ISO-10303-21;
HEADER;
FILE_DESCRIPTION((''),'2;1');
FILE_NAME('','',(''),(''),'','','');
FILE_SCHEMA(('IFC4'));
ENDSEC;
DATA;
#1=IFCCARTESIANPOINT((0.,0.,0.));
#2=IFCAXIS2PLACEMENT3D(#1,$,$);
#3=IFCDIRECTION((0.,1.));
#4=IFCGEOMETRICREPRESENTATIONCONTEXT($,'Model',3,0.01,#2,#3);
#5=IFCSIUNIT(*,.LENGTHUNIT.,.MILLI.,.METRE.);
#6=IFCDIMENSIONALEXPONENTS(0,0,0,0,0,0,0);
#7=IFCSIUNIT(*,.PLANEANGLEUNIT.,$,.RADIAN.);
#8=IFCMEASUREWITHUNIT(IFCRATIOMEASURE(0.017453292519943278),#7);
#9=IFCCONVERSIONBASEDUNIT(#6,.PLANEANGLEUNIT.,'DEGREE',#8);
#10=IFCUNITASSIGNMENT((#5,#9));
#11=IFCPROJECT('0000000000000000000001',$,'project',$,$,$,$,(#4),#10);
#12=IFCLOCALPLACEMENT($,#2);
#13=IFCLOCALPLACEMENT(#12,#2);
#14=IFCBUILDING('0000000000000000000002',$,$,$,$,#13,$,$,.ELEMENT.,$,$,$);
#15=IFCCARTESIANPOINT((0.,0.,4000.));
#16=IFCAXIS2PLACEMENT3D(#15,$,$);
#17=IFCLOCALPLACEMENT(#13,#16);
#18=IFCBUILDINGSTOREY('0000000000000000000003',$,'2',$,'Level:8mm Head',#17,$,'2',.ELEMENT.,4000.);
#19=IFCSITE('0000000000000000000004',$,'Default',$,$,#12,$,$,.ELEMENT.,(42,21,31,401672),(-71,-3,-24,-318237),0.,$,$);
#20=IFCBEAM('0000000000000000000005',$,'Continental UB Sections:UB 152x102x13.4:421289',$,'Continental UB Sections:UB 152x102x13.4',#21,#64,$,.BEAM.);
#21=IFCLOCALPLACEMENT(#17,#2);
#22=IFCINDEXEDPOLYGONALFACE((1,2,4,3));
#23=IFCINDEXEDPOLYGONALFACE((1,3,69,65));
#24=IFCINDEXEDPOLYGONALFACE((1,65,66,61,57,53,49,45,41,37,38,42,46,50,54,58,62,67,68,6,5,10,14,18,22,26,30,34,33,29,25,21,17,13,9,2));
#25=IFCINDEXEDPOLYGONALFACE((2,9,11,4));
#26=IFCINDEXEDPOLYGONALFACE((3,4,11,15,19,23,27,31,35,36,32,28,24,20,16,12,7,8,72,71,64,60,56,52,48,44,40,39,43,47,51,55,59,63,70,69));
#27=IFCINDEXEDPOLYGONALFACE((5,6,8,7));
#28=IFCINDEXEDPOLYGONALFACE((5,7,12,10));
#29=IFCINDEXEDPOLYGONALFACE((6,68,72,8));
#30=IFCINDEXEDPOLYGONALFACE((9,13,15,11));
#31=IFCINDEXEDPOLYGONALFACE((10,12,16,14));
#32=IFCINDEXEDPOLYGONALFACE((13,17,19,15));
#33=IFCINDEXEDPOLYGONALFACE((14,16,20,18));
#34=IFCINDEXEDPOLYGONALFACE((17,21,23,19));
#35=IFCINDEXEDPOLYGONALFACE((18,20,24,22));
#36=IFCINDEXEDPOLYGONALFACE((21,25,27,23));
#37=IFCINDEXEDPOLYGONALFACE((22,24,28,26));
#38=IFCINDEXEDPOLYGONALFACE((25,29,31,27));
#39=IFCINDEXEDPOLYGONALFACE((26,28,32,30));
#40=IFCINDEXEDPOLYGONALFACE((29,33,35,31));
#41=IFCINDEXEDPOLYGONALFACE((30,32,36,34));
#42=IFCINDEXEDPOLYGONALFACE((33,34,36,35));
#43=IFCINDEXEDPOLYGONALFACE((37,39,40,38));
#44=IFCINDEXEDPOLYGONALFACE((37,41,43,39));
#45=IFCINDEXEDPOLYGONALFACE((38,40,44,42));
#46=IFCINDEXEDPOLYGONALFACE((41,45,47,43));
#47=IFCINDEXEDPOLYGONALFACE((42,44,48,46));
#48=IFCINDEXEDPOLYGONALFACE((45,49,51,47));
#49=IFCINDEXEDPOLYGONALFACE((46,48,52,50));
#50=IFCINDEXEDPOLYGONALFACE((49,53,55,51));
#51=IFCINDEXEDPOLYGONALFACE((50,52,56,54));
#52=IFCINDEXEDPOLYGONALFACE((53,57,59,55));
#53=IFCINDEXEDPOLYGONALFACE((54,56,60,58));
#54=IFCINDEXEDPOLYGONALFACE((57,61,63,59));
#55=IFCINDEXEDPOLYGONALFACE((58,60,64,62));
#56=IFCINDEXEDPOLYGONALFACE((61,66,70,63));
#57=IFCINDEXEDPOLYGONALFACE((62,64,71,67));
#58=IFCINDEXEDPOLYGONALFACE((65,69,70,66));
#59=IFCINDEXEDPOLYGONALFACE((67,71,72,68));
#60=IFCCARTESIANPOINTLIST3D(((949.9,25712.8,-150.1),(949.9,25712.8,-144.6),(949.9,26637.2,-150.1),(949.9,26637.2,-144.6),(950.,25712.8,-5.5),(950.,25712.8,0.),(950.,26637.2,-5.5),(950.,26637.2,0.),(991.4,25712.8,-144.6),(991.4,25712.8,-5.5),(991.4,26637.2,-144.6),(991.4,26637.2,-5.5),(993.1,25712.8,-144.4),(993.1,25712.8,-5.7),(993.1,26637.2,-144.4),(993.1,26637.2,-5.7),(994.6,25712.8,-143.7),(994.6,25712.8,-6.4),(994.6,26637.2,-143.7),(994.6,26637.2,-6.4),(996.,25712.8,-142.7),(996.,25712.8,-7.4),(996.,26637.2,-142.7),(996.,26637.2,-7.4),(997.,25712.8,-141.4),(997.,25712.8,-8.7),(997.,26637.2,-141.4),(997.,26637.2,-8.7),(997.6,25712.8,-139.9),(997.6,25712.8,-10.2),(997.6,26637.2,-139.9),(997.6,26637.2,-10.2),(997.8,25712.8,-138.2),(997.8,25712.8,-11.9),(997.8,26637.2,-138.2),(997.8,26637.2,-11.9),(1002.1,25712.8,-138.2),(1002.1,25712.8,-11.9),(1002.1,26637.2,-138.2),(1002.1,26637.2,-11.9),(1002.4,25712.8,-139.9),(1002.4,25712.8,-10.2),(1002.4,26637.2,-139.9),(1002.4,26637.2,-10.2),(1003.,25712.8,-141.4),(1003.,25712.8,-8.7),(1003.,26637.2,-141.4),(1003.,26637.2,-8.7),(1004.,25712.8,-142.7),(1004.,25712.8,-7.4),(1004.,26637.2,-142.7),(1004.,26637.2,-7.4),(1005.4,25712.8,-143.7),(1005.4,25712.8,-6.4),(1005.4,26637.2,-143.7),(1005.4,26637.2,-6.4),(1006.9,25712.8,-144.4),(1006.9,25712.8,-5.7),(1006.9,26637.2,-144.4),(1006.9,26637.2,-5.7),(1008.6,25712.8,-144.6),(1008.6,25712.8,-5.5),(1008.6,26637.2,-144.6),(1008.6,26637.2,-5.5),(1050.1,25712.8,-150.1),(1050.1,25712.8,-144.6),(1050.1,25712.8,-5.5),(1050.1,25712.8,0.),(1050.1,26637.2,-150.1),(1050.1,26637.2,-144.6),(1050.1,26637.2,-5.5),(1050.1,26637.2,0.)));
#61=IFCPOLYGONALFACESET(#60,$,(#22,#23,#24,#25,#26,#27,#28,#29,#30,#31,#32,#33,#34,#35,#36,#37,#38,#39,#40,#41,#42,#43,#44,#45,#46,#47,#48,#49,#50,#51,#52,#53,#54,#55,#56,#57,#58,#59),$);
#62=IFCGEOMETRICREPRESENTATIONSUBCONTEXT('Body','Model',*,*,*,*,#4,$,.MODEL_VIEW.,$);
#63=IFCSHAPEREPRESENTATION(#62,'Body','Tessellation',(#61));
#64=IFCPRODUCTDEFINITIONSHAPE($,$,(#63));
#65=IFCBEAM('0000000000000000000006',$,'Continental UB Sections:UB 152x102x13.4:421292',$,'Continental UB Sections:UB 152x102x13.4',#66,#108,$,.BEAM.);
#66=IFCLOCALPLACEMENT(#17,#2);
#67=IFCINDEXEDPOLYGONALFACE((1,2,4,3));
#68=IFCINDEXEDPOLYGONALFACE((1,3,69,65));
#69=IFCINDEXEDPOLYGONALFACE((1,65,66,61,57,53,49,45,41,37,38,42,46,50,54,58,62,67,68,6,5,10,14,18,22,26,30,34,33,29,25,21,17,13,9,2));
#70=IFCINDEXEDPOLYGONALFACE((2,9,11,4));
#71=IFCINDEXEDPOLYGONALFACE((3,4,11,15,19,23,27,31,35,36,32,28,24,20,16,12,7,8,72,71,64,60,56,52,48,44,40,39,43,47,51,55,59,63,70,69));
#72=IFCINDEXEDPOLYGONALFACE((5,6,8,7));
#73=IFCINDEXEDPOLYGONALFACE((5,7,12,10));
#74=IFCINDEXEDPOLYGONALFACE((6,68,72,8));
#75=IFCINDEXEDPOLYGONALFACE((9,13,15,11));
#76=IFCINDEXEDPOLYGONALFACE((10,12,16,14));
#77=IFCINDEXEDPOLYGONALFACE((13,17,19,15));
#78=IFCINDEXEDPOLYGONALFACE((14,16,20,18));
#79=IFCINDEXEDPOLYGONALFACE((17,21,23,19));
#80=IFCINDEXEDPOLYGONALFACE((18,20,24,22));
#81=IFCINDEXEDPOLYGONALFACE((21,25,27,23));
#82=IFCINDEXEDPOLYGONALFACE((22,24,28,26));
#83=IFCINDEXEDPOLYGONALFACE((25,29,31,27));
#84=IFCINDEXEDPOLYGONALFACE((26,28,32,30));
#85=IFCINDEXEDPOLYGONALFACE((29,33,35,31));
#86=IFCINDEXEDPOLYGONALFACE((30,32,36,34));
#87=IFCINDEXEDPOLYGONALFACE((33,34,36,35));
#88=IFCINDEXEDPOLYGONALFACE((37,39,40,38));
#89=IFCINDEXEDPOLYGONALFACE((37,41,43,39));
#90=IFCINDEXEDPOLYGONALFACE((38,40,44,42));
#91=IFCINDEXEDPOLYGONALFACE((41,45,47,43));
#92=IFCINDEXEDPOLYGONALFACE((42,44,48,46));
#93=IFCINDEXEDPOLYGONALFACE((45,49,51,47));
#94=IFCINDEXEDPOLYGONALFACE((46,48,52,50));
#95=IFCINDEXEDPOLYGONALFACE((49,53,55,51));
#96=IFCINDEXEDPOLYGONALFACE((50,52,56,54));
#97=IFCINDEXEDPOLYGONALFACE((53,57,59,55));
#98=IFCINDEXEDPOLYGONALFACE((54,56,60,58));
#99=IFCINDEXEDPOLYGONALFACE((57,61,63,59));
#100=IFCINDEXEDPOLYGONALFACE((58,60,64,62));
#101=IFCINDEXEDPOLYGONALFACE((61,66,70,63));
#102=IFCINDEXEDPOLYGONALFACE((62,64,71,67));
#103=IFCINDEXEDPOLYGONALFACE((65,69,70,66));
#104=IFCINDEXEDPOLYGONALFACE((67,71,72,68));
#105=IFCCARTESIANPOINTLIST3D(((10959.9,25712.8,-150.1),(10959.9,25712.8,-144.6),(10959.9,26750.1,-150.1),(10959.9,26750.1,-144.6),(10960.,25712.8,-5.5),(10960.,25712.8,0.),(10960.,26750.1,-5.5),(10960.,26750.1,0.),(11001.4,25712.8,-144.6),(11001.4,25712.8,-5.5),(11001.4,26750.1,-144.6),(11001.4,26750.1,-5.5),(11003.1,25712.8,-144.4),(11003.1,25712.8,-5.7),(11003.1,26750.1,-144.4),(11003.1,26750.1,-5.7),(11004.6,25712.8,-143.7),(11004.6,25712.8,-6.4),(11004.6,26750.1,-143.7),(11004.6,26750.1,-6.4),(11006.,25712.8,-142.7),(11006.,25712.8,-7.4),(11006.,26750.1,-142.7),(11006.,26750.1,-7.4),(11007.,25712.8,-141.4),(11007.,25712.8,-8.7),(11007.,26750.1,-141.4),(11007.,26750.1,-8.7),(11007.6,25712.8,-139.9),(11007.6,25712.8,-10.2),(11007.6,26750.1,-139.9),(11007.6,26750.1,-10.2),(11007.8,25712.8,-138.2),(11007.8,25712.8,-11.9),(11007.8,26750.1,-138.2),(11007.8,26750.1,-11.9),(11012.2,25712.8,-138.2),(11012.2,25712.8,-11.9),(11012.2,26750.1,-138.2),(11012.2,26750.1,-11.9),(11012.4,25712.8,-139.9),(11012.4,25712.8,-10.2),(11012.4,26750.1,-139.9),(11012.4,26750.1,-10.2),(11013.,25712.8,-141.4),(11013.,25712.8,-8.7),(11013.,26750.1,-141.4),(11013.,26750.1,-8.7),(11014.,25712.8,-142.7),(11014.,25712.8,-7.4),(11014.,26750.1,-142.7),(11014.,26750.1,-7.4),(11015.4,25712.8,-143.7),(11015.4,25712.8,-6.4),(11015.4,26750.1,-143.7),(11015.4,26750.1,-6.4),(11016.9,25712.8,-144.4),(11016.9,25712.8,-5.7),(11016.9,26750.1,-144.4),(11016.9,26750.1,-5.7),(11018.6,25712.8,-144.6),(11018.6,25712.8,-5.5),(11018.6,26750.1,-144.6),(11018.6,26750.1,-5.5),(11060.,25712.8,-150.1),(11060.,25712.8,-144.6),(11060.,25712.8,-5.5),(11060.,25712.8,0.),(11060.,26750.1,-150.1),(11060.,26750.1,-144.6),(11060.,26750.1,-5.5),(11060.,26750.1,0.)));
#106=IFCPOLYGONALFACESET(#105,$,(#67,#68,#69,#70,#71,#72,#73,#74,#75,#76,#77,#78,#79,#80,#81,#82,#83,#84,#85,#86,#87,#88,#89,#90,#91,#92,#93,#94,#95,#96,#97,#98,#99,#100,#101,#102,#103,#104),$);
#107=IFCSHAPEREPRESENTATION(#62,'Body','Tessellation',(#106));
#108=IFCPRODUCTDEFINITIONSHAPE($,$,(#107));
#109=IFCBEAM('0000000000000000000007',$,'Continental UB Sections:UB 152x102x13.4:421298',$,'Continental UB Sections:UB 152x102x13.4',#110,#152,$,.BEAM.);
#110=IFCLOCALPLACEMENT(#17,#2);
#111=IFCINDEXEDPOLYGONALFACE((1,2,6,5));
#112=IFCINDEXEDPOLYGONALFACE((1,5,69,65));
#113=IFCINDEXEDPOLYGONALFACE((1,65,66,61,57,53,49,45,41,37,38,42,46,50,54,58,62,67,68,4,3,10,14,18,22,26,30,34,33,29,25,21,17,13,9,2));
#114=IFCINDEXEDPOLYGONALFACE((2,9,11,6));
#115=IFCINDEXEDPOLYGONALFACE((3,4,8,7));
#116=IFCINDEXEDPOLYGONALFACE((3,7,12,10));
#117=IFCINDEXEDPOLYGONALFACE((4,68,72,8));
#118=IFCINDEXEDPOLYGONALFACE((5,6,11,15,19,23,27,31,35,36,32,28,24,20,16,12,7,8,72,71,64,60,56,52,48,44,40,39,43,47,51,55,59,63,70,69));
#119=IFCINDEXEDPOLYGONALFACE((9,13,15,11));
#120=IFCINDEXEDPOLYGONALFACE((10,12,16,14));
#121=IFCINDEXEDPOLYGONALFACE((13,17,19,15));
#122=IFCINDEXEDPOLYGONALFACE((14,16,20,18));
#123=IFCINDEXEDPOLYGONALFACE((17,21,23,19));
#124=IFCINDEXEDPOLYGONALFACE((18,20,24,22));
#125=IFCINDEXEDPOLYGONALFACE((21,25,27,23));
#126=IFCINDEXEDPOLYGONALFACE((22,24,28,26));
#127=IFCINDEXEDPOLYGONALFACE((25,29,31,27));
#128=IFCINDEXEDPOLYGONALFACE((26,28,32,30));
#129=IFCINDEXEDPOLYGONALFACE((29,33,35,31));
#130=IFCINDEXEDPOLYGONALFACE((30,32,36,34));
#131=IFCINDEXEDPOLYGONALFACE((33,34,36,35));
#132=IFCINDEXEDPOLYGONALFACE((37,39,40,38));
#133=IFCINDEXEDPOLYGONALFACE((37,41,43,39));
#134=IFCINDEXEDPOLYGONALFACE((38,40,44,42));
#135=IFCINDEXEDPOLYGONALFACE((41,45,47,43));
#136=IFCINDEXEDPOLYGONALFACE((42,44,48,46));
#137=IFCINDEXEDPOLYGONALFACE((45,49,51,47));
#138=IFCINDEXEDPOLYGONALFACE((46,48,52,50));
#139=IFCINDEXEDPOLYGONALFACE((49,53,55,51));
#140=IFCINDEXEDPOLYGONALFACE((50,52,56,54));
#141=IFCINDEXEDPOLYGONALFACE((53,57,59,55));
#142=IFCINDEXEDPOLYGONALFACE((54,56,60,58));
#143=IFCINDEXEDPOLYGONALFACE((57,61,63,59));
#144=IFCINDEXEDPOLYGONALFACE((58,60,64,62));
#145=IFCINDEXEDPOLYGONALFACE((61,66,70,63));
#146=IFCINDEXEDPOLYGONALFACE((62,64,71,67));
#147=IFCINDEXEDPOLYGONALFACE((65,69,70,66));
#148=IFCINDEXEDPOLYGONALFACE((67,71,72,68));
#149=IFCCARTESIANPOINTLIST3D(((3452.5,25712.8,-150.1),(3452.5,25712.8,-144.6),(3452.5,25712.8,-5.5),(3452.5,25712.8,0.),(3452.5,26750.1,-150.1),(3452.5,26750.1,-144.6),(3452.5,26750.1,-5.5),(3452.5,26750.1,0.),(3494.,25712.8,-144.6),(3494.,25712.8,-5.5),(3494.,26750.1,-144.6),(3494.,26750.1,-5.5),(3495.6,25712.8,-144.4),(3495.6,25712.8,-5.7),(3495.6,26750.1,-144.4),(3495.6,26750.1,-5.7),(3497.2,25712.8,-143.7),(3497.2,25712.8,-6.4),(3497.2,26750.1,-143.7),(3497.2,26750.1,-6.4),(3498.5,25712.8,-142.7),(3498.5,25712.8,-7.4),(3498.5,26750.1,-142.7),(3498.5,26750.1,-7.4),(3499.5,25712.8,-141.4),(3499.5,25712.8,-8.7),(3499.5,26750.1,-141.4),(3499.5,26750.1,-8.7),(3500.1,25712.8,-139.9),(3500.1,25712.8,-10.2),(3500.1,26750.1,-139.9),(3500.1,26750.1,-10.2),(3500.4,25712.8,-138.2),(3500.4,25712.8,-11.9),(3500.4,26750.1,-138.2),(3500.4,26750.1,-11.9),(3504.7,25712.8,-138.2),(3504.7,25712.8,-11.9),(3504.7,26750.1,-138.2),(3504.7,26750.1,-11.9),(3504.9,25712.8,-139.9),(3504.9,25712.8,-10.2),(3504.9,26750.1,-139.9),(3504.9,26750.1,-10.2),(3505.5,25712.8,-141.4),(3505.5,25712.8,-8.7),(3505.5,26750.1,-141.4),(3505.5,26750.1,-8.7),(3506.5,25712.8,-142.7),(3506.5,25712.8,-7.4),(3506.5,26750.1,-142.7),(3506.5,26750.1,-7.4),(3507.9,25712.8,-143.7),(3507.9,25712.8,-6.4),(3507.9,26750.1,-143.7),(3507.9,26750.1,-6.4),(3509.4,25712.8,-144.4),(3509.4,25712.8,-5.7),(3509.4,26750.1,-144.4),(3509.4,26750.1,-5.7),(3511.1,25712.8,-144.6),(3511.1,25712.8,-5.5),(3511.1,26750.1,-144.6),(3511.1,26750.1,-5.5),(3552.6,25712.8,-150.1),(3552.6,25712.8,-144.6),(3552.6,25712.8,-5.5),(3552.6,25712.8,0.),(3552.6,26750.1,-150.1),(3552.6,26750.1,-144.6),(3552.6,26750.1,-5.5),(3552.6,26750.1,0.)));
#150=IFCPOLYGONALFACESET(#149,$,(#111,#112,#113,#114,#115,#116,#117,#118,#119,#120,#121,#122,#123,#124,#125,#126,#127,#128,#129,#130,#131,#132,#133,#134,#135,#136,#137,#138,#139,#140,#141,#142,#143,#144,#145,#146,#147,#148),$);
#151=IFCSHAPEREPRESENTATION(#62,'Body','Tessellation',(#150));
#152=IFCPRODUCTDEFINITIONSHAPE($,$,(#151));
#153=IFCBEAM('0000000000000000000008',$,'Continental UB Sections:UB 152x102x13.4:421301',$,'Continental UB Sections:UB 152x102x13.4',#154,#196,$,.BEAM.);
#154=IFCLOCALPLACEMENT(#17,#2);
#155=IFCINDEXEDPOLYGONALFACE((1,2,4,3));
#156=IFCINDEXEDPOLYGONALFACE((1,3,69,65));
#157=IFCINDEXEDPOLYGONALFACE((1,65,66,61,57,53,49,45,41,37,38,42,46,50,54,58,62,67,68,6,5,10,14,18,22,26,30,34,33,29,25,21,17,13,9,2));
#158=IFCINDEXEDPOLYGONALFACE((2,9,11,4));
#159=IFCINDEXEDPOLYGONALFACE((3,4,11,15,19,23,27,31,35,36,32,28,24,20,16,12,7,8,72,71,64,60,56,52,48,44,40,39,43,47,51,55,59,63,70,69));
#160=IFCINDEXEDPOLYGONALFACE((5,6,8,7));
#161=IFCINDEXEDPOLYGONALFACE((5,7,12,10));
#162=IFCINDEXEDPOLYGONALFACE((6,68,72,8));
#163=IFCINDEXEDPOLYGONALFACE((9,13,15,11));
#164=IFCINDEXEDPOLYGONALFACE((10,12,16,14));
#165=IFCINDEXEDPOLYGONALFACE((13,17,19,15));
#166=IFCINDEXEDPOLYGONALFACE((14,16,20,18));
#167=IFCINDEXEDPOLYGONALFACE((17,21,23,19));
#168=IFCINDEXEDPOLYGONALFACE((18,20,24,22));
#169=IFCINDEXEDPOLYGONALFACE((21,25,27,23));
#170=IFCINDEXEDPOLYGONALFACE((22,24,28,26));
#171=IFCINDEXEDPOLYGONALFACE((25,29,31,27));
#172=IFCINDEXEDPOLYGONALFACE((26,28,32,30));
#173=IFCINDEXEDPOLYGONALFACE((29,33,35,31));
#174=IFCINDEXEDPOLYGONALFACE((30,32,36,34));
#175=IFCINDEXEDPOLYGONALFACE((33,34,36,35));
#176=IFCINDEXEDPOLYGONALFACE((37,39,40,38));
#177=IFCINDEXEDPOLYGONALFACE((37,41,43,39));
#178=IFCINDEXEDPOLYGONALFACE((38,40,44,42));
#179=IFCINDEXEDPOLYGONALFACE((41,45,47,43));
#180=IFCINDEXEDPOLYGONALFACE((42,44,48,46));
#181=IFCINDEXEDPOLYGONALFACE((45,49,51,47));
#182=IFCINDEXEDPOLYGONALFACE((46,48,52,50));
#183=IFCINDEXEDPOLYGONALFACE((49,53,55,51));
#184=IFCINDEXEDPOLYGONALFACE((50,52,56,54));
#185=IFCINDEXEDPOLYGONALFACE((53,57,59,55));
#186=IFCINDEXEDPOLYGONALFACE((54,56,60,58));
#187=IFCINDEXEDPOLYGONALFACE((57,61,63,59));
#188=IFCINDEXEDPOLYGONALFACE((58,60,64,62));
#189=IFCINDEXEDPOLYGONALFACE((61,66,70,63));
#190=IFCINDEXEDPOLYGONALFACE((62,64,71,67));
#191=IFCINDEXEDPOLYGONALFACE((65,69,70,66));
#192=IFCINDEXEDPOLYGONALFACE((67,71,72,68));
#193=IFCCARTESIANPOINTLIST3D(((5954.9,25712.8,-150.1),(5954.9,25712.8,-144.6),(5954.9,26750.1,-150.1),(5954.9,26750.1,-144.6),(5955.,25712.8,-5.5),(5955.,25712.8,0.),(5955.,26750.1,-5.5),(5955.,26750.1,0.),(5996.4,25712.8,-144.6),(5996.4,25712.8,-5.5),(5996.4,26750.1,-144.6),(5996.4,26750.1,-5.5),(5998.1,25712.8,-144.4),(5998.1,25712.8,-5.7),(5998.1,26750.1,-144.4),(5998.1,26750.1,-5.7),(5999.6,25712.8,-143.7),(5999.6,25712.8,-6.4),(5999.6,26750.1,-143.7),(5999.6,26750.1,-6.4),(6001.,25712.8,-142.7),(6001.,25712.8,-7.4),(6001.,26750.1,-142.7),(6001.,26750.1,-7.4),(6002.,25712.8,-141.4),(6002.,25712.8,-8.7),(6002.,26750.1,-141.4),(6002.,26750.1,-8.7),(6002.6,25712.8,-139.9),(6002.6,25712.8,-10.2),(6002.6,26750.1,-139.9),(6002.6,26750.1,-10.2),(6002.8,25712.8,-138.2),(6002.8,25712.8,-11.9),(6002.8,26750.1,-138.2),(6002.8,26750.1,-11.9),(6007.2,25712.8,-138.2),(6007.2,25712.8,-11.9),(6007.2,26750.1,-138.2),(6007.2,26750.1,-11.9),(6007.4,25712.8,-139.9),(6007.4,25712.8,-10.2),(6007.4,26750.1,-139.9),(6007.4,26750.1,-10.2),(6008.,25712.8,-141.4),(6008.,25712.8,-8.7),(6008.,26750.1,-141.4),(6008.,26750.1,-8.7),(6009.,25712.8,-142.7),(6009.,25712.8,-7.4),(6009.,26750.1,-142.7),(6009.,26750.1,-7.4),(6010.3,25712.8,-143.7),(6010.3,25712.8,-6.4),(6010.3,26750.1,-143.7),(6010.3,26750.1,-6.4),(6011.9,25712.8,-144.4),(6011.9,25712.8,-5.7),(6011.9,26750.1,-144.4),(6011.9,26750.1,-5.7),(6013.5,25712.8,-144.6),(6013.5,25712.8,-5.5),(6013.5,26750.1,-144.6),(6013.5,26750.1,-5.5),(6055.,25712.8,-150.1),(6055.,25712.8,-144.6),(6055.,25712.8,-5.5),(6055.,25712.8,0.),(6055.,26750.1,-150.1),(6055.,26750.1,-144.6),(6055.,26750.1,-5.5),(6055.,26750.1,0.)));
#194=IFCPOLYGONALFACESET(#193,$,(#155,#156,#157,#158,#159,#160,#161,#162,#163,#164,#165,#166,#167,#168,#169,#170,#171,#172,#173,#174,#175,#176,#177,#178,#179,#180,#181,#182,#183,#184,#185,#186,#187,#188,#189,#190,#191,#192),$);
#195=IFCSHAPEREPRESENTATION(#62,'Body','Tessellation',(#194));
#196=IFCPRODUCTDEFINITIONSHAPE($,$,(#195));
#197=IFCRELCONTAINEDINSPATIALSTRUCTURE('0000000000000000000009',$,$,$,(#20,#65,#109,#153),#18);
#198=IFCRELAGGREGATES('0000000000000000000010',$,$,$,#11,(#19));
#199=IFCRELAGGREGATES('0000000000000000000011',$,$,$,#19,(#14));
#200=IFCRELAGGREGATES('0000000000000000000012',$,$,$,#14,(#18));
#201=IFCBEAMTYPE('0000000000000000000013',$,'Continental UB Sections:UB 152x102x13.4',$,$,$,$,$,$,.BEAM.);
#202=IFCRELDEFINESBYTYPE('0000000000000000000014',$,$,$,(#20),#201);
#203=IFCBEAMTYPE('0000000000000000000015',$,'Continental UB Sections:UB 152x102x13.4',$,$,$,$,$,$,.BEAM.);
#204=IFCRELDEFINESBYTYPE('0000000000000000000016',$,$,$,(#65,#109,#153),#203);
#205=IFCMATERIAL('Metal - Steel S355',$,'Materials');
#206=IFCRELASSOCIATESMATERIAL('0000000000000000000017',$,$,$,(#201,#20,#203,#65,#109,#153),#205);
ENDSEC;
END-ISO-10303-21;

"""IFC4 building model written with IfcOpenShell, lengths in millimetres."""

from ifc_helpers import new_model, entity, si_unit, converted_unit, direction, frame, origin, place, context, subcontext, project, spatial, line, arc, indexed_curve, outline, extrude, source, transform, mapped, material, type_object, type_shapes, element, save


model = new_model("IFC4")

# Units and contexts
model_context = context("Model", 3, precision=0.01, world=origin(), true_north=direction((0.0, 1.0)))
body_context = subcontext(model_context, "Body", "Model", "MODEL_VIEW")
ifc_project = project(units=[si_unit("LENGTHUNIT", "METRE", prefix="MILLI"), converted_unit("PLANEANGLEUNIT", "DEGREE", entity("IfcRatioMeasure", 0.017453292519943278), si_unit("PLANEANGLEUNIT", "RADIAN"), dimensions=[0, 0, 0, 0, 0, 0, 0])], contexts=[model_context])

# Site, building, storey
site_placement = place(None, origin())
site = spatial("IfcSite", under=ifc_project, at=site_placement, Name="Default", CompositionType="ELEMENT", RefLatitude=(42, 21, 31, 401672), RefLongitude=(-71, -3, -24, -318237), RefElevation=0.0)
building_placement = place(site_placement, origin())
building = spatial("IfcBuilding", under=site, at=building_placement, CompositionType="ELEMENT")
storey_placement = place(building_placement, frame((0.0, 0.0, 4000.0)))
storey = spatial("IfcBuildingStorey", under=building, at=storey_placement, Name="2", ObjectType="Level:8mm Head", LongName="2", CompositionType="ELEMENT", Elevation=4000.0)

# Beams
ifc_material_1 = material(Name="Metal - Steel S355", Category="Materials")
beam_type_1 = type_object("IfcBeamType", Name="Continental UB Sections:UB 152x102x13.4", PredefinedType="BEAM", material=ifc_material_1)
shared_shape_1 = source(origin(), body_context, "Body", "SweptSolid", [
    extrude(outline(indexed_curve([(-75.0, -50.1), (-69.6, -50.1), (-69.6, -8.5), (-67.7, -4.0), (-63.2, -2.1), (63.1, -2.1), (67.7, -4.0), (69.5, -8.5), (69.5, -50.1), (75.1, -50.1), (75.1, 50.1), (69.5, 50.1), (69.5, 8.6), (67.7, 4.0), (63.1, 2.2), (-63.2, 2.2), (-67.7, 4.0), (-69.6, 8.6), (-69.6, 50.0), (-75.0, 50.0)], segments=[line(1, 2, 3), arc(3, 4, 5), line(5, 6), arc(6, 7, 8), line(8, 9, 10, 11, 12, 13), arc(13, 14, 15), line(15, 16), arc(16, 17, 18), line(18, 19, 20, 1)], self_intersect=False)), frame((-487.2, 0.0, 0.0), z_axis=(1.0, 0.0, 0.0), x_axis=(0.0, 0.0, -1.0)), (0.0, 0.0, 1.0), 924.4),
])
type_shapes(beam_type_1, [shared_shape_1])
beam_1_placement = place(storey_placement, frame((1000.0, 26200.0, -75.1), z_axis=(0.0, 0.0, 1.0), x_axis=(0.0, 1.0, 0.0)))
element("IfcBeam", 1, at=beam_1_placement, inside=storey, type_object=beam_type_1, material=ifc_material_1, Name="Continental UB Sections:UB 152x102x13.4:421289", ObjectType="Continental UB Sections:UB 152x102x13.4", PredefinedType="BEAM", context=body_context, shape_type="MappedRepresentation", body=[
    mapped(shared_shape_1, transform((0.0, 0.0, 0.0), scale=1.0)),
])
beam_type_2 = type_object("IfcBeamType", Name="Continental UB Sections:UB 152x102x13.4", PredefinedType="BEAM", material=ifc_material_1)
shared_shape_2 = source(origin(), body_context, "Body", "SweptSolid", [
    extrude(outline(indexed_curve([(-75.0, -50.1), (-69.6, -50.1), (-69.6, -8.5), (-67.7, -4.0), (-63.2, -2.1), (63.1, -2.1), (67.7, -4.0), (69.5, -8.5), (69.5, -50.1), (75.1, -50.1), (75.1, 50.1), (69.5, 50.1), (69.5, 8.6), (67.7, 4.0), (63.1, 2.2), (-63.2, 2.2), (-67.7, 4.0), (-69.6, 8.6), (-69.6, 50.0), (-75.0, 50.0)], segments=[line(1, 2, 3), arc(3, 4, 5), line(5, 6), arc(6, 7, 8), line(8, 9, 10, 11, 12, 13), arc(13, 14, 15), line(15, 16), arc(16, 17, 18), line(18, 19, 20, 1)], self_intersect=False)), frame((-487.2, 0.0, 0.0), z_axis=(1.0, 0.0, 0.0), x_axis=(0.0, 0.0, -1.0)), (0.0, 0.0, 1.0), 1037.3),
])
type_shapes(beam_type_2, [shared_shape_2])
for number, where, z_axis, x_axis, name in (
    (2, (11010.0, 26200.0, -75.1), (0.0, 0.0, 1.0), (0.0, 1.0, 0.0), "Continental UB Sections:UB 152x102x13.4:421292"),
    (3, (3502.5, 26200.0, -75.1), (0.0, 0.0, 1.0), (0.0, 1.0, 0.0), "Continental UB Sections:UB 152x102x13.4:421298"),
    (4, (6005.0, 26200.0, -75.1), (0.0, 0.0, 1.0), (0.0, 1.0, 0.0), "Continental UB Sections:UB 152x102x13.4:421301"),
):
    element("IfcBeam", number, at=place(storey_placement, frame(where, z_axis=z_axis, x_axis=x_axis)), inside=storey, type_object=beam_type_2, material=ifc_material_1, Name=name, ObjectType="Continental UB Sections:UB 152x102x13.4", PredefinedType="BEAM", context=body_context, shape_type="MappedRepresentation", body=[
        mapped(shared_shape_2, transform((0.0, 0.0, 0.0), scale=1.0)),
    ])

save(model, "model.ifc")
